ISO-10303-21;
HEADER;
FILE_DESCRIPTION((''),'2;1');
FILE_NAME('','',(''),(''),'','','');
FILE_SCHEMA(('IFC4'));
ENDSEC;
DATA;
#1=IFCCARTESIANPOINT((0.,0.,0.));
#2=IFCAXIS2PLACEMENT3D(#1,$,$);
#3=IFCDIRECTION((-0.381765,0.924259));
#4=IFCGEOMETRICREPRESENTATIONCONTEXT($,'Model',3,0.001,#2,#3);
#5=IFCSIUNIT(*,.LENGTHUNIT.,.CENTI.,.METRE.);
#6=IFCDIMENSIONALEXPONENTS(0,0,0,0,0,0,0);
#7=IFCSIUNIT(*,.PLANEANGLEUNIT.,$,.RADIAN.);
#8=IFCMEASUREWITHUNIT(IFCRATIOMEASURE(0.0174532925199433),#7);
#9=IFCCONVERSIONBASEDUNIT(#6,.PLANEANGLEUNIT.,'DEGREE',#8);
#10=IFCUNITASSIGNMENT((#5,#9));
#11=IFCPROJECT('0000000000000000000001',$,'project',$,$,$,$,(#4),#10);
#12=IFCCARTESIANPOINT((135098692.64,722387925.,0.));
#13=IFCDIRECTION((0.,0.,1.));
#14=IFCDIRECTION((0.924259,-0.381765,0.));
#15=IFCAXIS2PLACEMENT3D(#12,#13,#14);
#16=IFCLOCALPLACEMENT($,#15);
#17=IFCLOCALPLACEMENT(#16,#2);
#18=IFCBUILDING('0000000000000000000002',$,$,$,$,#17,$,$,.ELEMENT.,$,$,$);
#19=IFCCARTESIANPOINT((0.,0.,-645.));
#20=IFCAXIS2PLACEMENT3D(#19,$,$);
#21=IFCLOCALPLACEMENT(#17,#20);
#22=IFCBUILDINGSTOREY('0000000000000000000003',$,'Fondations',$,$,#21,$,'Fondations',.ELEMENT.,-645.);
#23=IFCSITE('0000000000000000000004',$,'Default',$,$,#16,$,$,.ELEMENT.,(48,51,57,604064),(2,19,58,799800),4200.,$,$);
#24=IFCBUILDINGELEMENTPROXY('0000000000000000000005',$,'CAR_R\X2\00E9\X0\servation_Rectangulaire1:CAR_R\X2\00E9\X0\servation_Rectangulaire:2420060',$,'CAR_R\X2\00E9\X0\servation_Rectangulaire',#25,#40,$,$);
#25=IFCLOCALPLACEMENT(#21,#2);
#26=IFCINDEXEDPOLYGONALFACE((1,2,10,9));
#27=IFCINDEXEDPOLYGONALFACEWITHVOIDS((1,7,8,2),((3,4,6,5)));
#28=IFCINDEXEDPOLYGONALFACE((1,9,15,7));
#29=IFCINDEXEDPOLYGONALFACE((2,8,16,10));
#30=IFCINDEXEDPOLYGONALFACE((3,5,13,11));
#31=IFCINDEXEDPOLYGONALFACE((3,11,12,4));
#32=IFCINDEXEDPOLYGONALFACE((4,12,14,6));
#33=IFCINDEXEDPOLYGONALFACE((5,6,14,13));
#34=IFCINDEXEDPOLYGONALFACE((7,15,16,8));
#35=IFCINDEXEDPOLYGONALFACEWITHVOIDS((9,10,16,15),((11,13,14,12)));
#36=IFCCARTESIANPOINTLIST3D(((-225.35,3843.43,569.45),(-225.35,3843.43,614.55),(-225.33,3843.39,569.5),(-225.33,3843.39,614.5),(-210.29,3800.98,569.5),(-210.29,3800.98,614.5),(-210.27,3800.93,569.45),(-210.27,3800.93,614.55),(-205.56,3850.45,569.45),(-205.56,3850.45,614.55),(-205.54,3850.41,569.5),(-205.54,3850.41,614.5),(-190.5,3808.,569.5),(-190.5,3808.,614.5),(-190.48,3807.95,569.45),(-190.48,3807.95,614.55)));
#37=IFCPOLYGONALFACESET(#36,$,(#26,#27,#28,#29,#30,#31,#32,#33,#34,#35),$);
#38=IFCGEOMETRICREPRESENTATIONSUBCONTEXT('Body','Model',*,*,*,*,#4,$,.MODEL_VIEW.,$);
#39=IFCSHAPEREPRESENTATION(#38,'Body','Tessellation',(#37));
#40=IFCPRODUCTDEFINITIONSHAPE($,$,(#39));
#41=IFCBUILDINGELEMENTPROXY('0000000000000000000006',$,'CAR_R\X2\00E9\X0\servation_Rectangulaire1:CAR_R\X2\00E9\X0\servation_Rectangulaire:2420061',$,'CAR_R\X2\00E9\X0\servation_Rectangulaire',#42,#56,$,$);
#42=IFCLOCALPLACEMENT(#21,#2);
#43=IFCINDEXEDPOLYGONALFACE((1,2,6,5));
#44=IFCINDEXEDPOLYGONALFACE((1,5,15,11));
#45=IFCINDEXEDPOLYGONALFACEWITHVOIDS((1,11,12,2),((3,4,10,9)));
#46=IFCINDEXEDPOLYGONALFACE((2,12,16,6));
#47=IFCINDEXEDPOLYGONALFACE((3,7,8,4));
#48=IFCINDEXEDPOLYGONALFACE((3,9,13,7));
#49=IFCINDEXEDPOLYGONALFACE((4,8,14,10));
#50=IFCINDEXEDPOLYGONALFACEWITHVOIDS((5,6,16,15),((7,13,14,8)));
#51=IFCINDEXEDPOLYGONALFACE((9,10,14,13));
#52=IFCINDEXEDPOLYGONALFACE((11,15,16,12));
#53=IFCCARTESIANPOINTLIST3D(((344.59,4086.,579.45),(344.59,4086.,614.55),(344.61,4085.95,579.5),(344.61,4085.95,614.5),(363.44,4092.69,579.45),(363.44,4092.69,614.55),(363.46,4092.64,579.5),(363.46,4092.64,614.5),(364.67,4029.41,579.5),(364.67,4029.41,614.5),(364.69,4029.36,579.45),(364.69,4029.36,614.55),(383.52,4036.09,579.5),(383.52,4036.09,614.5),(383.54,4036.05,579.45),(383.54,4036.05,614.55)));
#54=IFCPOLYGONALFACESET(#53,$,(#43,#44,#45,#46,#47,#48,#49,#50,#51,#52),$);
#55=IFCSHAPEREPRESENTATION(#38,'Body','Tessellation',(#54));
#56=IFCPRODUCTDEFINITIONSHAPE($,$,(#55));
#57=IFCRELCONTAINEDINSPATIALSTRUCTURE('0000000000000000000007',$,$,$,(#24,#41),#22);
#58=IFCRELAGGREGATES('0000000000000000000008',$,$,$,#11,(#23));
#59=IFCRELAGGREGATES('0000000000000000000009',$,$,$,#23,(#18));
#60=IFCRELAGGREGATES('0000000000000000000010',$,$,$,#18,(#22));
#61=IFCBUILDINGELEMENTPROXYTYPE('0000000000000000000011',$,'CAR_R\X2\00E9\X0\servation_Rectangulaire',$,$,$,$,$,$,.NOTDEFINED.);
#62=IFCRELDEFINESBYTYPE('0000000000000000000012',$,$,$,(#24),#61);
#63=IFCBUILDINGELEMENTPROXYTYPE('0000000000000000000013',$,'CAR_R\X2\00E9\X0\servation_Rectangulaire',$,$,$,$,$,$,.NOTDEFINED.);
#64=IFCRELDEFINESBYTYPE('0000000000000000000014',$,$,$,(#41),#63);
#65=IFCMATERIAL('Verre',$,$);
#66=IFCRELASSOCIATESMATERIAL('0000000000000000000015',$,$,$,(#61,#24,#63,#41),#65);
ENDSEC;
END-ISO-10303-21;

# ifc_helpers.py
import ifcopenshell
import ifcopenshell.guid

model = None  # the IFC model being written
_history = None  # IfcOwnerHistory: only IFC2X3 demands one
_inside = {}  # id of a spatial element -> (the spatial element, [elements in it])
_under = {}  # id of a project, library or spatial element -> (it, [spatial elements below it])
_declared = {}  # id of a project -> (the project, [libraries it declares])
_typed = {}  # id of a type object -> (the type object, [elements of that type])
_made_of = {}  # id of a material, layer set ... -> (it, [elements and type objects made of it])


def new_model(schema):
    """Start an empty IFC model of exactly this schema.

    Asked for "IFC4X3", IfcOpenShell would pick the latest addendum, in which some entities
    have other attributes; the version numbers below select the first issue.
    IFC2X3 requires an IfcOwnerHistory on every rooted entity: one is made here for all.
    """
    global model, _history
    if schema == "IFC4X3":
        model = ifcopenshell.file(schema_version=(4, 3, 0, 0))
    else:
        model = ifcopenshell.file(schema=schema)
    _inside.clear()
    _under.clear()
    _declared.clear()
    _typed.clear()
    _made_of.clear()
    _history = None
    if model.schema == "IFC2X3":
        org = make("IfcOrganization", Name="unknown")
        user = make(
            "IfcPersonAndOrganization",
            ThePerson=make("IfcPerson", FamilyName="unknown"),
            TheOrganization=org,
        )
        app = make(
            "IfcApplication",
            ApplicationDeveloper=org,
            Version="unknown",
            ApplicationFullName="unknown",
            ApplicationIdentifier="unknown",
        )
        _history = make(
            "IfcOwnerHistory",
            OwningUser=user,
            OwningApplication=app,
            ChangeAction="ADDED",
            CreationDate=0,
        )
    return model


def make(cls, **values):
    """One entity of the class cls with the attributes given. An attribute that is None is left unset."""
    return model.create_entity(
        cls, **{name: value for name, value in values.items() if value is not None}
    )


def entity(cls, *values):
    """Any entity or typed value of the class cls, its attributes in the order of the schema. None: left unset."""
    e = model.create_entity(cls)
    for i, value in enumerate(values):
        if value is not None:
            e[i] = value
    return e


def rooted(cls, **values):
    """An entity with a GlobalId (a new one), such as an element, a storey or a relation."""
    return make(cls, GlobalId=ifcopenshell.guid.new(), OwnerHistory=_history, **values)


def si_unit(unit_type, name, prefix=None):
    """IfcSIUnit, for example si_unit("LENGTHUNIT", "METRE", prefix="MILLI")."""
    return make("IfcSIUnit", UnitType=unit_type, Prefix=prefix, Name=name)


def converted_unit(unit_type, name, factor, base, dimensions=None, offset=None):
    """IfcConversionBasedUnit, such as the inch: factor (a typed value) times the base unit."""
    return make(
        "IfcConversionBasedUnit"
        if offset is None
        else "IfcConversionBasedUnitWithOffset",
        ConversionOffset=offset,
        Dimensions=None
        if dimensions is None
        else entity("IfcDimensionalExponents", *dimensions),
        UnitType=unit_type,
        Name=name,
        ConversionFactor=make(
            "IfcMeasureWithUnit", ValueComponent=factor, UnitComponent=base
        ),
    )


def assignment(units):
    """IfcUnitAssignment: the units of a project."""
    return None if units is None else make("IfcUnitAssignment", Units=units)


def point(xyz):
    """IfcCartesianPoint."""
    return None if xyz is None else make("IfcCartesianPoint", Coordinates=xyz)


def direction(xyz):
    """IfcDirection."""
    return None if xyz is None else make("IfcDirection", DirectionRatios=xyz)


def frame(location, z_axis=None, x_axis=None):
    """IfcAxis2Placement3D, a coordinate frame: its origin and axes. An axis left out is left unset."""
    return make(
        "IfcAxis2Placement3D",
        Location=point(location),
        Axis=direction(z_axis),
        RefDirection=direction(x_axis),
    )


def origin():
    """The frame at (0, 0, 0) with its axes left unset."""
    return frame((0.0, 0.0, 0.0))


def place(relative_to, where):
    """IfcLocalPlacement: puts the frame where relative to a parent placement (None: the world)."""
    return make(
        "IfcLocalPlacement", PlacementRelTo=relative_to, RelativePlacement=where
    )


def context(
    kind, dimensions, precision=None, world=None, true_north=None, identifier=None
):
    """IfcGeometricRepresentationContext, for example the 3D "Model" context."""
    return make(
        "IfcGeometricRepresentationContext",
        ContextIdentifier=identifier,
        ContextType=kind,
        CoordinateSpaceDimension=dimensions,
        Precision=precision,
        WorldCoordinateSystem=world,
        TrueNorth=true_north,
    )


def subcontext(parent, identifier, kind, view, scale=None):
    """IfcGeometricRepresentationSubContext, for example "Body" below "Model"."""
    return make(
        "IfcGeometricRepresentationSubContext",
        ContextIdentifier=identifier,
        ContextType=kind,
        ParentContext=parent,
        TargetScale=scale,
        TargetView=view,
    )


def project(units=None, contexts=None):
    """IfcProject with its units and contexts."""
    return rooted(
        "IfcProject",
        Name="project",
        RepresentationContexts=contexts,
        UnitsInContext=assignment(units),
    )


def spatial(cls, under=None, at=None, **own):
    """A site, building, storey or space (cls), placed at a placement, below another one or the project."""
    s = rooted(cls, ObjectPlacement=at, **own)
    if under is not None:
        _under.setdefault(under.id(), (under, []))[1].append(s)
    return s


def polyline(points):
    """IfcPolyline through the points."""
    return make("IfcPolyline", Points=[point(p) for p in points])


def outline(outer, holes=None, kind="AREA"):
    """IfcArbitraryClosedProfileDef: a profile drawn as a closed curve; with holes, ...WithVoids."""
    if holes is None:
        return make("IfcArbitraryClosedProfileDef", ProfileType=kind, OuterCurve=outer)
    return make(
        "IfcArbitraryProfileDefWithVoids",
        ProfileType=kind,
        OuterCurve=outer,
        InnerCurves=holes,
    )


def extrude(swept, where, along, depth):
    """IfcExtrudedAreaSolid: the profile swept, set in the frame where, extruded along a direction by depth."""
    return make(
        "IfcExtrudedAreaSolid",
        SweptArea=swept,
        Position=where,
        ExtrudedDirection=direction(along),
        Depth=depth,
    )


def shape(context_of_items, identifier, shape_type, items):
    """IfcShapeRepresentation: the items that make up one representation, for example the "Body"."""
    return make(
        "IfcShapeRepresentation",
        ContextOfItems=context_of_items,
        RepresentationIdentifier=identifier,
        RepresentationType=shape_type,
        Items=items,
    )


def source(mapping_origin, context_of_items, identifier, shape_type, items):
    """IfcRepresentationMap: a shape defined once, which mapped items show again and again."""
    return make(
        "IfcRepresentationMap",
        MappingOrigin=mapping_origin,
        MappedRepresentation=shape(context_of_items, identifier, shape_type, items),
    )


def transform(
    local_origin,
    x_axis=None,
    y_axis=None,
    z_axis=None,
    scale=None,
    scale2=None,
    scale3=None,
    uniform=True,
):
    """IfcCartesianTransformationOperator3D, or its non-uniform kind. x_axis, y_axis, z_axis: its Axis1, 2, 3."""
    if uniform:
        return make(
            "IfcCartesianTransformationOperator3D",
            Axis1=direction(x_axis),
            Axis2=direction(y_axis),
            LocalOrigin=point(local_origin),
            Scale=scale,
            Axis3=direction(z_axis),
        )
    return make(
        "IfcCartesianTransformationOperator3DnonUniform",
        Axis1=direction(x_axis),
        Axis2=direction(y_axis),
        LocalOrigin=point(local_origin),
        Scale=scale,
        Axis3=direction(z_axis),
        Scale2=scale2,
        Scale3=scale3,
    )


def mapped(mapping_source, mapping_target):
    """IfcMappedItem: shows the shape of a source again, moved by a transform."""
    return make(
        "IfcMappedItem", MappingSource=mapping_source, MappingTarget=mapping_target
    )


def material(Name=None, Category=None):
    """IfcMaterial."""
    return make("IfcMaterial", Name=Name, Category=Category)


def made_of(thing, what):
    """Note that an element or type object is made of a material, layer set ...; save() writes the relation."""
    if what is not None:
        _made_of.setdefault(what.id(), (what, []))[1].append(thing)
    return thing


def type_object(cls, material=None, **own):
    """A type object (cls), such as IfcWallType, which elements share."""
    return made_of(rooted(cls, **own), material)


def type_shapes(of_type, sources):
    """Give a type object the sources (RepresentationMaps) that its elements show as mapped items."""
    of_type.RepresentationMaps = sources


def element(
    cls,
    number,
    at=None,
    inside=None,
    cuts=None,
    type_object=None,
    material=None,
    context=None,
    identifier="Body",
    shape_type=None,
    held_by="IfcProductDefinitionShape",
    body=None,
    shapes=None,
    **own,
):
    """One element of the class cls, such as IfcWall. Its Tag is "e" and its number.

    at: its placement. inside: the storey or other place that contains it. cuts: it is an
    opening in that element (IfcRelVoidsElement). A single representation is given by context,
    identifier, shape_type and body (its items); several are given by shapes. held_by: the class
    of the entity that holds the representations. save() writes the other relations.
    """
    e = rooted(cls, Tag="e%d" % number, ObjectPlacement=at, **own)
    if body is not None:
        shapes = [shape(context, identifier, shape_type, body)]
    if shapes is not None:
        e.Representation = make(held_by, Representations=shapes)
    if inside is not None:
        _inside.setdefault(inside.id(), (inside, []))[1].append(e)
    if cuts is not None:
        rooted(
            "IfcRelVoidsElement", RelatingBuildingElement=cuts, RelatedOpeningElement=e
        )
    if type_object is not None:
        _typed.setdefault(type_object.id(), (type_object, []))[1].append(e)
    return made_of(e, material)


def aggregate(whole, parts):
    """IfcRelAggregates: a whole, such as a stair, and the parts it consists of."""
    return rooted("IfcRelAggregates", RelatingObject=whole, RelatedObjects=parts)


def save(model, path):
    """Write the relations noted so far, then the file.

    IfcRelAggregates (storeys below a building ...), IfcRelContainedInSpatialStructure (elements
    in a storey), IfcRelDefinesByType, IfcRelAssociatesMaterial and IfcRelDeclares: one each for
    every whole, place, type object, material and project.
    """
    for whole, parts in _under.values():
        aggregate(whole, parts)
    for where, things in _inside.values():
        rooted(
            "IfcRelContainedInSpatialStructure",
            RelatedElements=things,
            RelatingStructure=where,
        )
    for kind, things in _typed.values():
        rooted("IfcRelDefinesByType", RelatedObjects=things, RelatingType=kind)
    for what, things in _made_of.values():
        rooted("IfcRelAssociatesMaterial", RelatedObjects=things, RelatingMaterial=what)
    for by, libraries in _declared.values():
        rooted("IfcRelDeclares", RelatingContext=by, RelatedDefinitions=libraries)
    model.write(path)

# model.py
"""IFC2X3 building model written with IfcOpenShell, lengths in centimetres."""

from ifc_helpers import new_model, entity, si_unit, converted_unit, direction, frame, origin, place, context, subcontext, project, spatial, polyline, outline, extrude, source, transform, mapped, material, type_object, type_shapes, element, save


model = new_model("IFC2X3")

# Units and contexts
model_context = context("Model", 3, precision=0.001, world=origin(), true_north=direction((-0.381765, 0.924259)))
body_context = subcontext(model_context, "Body", "Model", "MODEL_VIEW")
ifc_project = project(units=[si_unit("LENGTHUNIT", "METRE", prefix="CENTI"), converted_unit("PLANEANGLEUNIT", "DEGREE", entity("IfcRatioMeasure", 0.0174532925199433), si_unit("PLANEANGLEUNIT", "RADIAN"), dimensions=[0, 0, 0, 0, 0, 0, 0])], contexts=[model_context])

# Site, building, storey
site_placement = place(None, frame((135098692.64, 722387925.0, 0.0), z_axis=(0.0, 0.0, 1.0), x_axis=(0.924259, -0.381765, 0.0)))
site = spatial("IfcSite", under=ifc_project, at=site_placement, Name="Default", CompositionType="ELEMENT", RefLatitude=(48, 51, 57, 604064), RefLongitude=(2, 19, 58, 799800), RefElevation=4200.0)
building_placement = place(site_placement, origin())
building = spatial("IfcBuilding", under=site, at=building_placement, CompositionType="ELEMENT")
storey_placement = place(building_placement, frame((0.0, 0.0, -645.0)))
storey = spatial("IfcBuildingStorey", under=building, at=storey_placement, Name="Fondations", LongName="Fondations", CompositionType="ELEMENT", Elevation=-645.0)

# Building element proxies
ifc_material_1 = material(Name="Verre")
building_element_proxy_type_1 = type_object("IfcBuildingElementProxyType", Name="CAR_Réservation_Rectangulaire", PredefinedType="NOTDEFINED", material=ifc_material_1)
shared_shape_1 = source(origin(), body_context, "Body", "SweptSolid", [
    extrude(outline(polyline([(-22.55, -22.55), (22.55, -22.55), (22.55, 22.55), (-22.55, 22.55), (-22.55, -22.55)]), holes=[polyline([(22.5, -22.5), (-22.5, -22.5), (-22.5, 22.5), (22.5, 22.5), (22.5, -22.5)])]), frame((0.0, 0.0, -21.0), z_axis=(0.0, 0.0, 1.0), x_axis=(-1.0, 0.0, 0.0)), (0.0, 0.0, 1.0), 21.0),
])
type_shapes(building_element_proxy_type_1, [shared_shape_1])
proxy_1_placement = place(storey_placement, frame((-217.81, 3822.18, 592.0), z_axis=(-0.942455, -0.334334, 0.0), x_axis=(0.334334, -0.942455, 0.0)))
element("IfcBuildingElementProxy", 1, at=proxy_1_placement, inside=storey, type_object=building_element_proxy_type_1, material=ifc_material_1, Name="CAR_Réservation_Rectangulaire1:CAR_Réservation_Rectangulaire:2420060", ObjectType="CAR_Réservation_Rectangulaire", context=body_context, shape_type="MappedRepresentation", body=[
    mapped(shared_shape_1, transform((0.0, 0.0, 0.0), scale=1.0)),
])
building_element_proxy_type_2 = type_object("IfcBuildingElementProxyType", Name="CAR_Réservation_Rectangulaire", PredefinedType="NOTDEFINED", material=ifc_material_1)
shared_shape_2 = source(origin(), body_context, "Body", "SweptSolid", [
    extrude(outline(polyline([(-30.05, -17.55), (30.05, -17.55), (30.05, 17.55), (-30.05, 17.55), (-30.05, -17.55)]), holes=[polyline([(30.0, -17.5), (-30.0, -17.5), (-30.0, 17.5), (30.0, 17.5), (30.0, -17.5)])]), frame((0.0, 0.0, -20.0), z_axis=(0.0, 0.0, 1.0), x_axis=(-1.0, 0.0, 0.0)), (0.0, 0.0, 1.0), 20.0),
])
type_shapes(building_element_proxy_type_2, [shared_shape_2])
proxy_2_placement = place(storey_placement, frame((373.49, 4064.37, 597.0), z_axis=(0.942456, 0.334331, 0.0), x_axis=(-0.334331, 0.942456, 0.0)))
element("IfcBuildingElementProxy", 2, at=proxy_2_placement, inside=storey, type_object=building_element_proxy_type_2, material=ifc_material_1, Name="CAR_Réservation_Rectangulaire1:CAR_Réservation_Rectangulaire:2420061", ObjectType="CAR_Réservation_Rectangulaire", context=body_context, shape_type="MappedRepresentation", body=[
    mapped(shared_shape_2, transform((0.0, 0.0, 0.0), scale=1.0)),
])

save(model, "model.ifc")
